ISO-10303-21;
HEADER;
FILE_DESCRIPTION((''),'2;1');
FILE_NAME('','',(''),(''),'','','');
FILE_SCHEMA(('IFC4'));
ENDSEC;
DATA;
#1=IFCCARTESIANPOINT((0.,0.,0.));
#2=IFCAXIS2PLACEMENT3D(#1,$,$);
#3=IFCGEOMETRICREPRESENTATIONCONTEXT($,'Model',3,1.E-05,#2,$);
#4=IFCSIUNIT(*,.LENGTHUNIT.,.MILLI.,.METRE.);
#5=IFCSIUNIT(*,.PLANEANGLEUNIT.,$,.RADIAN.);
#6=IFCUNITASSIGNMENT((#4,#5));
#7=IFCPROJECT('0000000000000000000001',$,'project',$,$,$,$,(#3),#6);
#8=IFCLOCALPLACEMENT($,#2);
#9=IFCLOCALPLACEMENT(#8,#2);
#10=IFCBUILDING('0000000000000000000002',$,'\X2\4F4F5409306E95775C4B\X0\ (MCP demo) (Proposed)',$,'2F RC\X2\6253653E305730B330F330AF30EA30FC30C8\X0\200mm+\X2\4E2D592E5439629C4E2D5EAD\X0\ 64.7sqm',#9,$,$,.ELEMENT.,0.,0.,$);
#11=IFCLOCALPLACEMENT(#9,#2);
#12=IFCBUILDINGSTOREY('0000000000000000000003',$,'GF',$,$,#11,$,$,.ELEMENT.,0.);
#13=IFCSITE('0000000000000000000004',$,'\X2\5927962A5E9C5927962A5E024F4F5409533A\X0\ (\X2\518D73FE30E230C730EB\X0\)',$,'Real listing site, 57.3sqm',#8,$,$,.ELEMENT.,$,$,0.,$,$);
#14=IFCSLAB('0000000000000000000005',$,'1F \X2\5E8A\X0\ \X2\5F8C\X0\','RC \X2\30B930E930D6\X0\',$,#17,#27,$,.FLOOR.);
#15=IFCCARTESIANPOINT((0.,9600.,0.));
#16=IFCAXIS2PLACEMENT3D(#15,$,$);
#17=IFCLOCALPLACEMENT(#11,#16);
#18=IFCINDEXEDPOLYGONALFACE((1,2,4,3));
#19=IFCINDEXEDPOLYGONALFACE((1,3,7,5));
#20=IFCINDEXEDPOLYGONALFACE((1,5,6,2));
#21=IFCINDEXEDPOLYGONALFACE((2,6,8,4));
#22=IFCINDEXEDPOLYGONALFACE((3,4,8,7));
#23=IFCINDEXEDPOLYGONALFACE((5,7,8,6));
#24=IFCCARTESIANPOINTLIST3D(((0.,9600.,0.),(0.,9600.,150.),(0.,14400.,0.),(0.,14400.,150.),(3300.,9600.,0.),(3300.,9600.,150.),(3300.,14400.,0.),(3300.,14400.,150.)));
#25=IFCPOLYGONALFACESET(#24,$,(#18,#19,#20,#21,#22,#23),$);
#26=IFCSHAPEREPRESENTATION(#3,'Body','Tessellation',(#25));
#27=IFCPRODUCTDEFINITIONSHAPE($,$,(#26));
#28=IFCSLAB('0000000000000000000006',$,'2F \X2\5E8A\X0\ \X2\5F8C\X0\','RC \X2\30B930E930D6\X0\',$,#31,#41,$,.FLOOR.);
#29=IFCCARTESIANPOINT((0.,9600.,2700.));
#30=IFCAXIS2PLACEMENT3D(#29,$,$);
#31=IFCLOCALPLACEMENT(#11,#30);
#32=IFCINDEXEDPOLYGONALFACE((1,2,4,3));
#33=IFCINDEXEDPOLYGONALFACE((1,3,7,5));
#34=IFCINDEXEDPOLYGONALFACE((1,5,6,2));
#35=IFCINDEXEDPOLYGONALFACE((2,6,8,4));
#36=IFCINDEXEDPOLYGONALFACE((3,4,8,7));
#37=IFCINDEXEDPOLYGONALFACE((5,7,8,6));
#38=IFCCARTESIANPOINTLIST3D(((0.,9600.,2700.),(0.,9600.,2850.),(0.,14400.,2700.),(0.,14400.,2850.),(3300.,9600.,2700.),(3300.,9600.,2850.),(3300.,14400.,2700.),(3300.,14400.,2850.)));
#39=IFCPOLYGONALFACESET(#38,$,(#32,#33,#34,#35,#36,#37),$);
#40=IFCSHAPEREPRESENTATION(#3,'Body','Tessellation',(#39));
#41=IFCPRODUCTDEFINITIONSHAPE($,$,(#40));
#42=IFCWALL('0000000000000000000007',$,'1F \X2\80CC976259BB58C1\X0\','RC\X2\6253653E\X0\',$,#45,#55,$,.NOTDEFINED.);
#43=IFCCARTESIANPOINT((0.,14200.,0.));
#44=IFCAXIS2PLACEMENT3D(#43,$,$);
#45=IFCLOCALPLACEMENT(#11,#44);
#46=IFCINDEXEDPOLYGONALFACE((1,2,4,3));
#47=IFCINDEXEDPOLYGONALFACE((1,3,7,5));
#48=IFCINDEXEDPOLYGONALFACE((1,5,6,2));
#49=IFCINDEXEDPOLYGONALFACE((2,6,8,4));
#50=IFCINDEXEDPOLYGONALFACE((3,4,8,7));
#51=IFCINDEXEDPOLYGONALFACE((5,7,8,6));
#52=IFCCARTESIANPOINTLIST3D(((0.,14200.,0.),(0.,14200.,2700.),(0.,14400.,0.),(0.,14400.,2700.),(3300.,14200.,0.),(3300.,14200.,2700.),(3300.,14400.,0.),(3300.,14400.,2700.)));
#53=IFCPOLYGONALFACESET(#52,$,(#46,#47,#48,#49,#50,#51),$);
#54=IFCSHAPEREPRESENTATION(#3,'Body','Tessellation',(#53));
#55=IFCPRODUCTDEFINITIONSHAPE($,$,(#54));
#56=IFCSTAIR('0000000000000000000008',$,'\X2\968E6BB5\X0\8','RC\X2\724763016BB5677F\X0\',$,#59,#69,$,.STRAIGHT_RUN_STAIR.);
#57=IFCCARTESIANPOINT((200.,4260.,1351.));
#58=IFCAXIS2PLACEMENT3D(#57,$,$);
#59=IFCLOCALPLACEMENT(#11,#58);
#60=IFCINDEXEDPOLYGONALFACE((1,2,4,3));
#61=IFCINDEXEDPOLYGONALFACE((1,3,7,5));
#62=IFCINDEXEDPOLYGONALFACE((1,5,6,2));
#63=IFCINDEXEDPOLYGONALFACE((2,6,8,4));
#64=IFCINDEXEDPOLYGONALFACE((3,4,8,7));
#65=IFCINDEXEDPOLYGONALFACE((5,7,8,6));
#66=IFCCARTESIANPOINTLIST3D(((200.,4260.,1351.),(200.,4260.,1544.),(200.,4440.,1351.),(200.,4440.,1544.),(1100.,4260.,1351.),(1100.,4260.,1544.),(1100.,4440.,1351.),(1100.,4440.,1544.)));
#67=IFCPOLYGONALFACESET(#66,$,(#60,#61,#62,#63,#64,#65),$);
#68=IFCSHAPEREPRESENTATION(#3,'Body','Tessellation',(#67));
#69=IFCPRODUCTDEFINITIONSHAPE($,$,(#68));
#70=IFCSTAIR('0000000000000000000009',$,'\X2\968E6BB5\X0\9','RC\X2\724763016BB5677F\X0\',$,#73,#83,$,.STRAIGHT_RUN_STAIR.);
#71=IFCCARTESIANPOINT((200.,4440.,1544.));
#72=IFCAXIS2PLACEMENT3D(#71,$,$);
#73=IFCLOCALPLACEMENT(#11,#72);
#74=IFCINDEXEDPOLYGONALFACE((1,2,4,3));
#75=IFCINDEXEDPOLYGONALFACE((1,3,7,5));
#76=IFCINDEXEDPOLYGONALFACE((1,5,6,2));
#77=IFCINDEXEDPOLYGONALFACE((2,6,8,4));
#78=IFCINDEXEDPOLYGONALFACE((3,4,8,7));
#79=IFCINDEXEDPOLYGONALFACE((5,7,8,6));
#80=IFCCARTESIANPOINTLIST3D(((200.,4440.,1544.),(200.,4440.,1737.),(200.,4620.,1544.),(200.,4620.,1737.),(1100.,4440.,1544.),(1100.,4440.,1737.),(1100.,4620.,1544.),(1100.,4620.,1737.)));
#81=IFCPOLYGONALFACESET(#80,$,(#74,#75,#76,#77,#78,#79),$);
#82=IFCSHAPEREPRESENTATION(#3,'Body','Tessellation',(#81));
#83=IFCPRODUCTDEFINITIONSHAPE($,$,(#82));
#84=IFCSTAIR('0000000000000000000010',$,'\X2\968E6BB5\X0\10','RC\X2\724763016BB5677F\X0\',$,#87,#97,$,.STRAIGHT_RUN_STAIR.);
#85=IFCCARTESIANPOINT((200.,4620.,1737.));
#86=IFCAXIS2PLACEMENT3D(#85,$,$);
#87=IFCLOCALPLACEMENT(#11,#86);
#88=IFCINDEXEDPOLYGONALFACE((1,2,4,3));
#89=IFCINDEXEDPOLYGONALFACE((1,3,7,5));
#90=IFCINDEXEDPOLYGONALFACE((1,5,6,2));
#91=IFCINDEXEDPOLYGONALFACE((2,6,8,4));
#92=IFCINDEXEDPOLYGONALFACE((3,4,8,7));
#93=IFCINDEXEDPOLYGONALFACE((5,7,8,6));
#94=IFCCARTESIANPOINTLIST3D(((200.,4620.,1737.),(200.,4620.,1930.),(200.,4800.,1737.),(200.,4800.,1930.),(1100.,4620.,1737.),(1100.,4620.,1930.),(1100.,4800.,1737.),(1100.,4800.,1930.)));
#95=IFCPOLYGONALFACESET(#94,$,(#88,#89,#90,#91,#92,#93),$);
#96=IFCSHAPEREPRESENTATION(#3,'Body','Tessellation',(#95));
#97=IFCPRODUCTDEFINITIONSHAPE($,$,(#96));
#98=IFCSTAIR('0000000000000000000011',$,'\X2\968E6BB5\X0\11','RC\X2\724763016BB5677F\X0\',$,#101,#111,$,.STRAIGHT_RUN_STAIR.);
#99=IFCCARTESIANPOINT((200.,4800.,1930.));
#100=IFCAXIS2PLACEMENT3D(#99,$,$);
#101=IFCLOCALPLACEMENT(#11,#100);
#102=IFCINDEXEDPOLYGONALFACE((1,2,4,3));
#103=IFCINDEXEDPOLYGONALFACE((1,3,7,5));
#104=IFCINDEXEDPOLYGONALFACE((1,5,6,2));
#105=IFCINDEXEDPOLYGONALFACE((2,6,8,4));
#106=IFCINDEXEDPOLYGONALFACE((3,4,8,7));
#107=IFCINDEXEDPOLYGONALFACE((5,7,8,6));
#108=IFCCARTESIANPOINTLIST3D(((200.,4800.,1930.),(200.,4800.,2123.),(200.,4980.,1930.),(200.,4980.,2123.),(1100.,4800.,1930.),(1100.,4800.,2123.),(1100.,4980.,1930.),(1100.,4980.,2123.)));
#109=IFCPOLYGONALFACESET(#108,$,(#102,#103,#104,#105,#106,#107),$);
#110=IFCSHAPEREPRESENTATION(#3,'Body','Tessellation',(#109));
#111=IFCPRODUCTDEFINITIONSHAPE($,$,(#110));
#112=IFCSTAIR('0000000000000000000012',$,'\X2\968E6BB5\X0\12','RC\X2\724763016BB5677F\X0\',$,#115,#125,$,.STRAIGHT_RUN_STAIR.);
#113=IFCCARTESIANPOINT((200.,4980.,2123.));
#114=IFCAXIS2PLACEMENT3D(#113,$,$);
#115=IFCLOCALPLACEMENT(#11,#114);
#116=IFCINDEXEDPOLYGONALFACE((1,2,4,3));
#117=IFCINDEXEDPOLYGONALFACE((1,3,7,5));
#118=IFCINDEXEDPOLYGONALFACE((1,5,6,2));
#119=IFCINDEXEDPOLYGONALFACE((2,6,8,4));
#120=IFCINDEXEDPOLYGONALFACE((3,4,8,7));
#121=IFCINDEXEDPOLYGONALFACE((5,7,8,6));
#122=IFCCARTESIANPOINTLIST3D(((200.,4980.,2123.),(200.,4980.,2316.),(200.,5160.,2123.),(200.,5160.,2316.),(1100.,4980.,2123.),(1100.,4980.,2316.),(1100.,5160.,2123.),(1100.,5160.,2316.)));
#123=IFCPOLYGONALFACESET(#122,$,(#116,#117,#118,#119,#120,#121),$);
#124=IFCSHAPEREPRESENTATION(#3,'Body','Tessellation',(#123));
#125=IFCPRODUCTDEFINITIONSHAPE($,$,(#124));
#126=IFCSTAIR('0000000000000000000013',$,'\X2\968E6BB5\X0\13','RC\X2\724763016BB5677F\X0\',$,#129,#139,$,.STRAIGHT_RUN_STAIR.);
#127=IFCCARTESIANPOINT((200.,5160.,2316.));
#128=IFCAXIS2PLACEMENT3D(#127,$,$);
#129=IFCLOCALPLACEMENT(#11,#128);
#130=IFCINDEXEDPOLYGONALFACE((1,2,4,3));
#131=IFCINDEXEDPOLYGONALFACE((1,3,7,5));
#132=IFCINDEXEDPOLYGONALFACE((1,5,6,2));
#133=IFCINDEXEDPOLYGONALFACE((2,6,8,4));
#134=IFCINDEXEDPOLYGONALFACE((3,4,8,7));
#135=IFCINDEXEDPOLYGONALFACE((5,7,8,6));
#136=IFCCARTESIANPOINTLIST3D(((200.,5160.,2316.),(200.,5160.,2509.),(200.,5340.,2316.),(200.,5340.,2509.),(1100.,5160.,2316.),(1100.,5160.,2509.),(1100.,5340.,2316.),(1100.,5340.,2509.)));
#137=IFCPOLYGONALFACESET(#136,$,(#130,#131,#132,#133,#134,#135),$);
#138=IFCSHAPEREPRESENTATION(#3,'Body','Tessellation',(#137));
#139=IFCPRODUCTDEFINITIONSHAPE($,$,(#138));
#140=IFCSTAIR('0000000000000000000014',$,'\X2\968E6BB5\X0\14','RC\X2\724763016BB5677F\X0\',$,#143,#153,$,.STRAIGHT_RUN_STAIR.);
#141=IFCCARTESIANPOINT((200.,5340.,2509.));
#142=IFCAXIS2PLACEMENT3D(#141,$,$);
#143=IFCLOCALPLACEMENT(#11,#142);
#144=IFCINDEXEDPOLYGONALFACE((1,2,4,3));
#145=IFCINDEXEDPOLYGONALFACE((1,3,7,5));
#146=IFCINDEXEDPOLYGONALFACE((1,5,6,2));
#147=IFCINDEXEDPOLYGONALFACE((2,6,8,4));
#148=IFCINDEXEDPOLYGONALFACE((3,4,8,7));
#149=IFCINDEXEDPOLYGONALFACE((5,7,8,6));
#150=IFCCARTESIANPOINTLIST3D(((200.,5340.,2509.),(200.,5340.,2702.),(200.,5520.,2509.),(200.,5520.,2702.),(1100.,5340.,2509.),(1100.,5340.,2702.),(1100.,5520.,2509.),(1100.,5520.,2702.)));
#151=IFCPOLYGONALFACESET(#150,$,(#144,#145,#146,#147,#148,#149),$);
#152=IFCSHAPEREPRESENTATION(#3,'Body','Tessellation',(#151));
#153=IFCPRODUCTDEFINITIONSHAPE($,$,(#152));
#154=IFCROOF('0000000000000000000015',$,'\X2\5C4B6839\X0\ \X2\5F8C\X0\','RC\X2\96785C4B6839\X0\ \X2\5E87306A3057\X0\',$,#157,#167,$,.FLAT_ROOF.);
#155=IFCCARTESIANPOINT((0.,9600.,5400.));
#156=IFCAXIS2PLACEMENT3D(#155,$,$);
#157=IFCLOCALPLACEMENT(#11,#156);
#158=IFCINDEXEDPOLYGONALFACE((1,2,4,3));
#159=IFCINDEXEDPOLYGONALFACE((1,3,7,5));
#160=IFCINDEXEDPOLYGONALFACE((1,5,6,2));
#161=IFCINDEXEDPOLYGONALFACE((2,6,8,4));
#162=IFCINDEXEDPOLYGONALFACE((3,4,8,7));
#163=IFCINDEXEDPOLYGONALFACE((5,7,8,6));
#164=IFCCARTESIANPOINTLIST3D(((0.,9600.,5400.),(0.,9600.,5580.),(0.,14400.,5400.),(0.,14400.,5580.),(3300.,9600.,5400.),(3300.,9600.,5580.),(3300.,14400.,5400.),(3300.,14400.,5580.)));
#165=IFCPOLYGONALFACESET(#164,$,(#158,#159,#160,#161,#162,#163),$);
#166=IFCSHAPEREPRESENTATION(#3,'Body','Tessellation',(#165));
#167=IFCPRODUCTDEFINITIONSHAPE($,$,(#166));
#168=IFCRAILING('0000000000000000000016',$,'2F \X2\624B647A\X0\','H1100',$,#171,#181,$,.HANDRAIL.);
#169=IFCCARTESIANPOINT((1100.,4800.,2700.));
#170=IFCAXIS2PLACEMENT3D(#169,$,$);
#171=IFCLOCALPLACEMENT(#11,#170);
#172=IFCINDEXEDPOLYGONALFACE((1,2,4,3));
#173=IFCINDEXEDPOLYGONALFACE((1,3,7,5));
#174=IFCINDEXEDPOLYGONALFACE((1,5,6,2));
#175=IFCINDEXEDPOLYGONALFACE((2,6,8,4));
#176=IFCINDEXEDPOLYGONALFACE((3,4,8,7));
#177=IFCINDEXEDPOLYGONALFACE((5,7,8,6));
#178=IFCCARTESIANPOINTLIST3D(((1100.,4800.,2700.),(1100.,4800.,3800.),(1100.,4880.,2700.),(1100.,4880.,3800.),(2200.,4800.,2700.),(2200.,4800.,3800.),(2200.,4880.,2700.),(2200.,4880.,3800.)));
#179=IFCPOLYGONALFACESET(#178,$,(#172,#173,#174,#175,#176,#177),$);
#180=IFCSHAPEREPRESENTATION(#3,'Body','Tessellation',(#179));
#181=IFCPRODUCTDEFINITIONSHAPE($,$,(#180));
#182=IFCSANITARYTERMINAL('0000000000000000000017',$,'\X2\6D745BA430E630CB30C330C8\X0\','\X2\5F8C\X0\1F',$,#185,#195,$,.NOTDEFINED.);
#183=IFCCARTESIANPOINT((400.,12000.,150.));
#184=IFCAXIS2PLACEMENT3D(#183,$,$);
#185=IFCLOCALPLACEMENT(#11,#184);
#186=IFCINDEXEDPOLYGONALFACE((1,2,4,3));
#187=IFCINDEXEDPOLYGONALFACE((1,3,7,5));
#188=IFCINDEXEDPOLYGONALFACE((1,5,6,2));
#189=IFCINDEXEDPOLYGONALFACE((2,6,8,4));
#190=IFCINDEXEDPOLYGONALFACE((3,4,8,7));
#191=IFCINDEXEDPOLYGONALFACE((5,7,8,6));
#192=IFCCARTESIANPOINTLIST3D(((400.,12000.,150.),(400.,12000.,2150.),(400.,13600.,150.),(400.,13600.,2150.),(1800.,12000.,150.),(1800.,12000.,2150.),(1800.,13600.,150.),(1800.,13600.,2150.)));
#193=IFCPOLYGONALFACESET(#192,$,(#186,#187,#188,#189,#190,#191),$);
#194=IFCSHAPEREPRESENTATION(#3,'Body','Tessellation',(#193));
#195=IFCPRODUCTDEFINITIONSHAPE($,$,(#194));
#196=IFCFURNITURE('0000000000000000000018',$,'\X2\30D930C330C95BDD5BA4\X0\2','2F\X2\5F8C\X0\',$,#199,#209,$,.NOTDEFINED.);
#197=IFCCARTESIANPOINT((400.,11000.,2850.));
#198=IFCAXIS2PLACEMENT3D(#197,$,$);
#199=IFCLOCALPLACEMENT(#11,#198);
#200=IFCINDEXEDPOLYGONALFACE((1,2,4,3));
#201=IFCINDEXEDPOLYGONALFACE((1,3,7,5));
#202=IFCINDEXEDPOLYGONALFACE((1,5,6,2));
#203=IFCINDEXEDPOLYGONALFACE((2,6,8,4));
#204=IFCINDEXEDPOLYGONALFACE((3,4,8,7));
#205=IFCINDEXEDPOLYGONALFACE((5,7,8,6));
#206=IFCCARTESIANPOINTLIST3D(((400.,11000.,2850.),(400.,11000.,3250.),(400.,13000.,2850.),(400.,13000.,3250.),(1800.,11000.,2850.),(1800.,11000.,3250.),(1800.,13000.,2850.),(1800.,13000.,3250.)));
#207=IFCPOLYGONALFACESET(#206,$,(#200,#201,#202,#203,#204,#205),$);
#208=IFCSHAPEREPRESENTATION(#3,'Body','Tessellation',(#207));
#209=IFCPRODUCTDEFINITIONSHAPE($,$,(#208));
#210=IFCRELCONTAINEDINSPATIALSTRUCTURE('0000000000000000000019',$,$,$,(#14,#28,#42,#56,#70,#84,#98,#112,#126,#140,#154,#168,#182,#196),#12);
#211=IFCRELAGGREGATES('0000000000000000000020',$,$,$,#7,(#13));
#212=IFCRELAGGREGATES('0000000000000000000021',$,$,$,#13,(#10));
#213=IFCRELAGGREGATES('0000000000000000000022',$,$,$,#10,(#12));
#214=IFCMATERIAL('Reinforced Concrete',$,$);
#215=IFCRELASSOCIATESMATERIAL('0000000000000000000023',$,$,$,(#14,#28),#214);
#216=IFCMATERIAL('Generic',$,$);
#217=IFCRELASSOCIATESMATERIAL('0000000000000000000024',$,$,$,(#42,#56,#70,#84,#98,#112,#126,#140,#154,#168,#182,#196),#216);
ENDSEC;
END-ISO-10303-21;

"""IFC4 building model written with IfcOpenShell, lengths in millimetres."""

from ifc_helpers import new_model, si_unit, frame, frame_2d, origin, place, context, project, spatial, rectangle, extrude, material, element, save


model = new_model("IFC4")

# Units and contexts
model_context = context("Model", 3, precision=1e-05, world=origin())
ifc_project = project(units=[si_unit("LENGTHUNIT", "METRE", prefix="MILLI"), si_unit("PLANEANGLEUNIT", "RADIAN")], contexts=[model_context])

# Site, building, storey
site_placement = place(None, origin())
site = spatial("IfcSite", under=ifc_project, at=site_placement, Name="大阪府大阪市住吉区 (再現モデル)", ObjectType="Real listing site, 57.3sqm", CompositionType="ELEMENT", RefElevation=0.0)
building_placement = place(site_placement, origin())
building = spatial("IfcBuilding", under=site, at=building_placement, Name="住吉の長屋 (MCP demo) (Proposed)", ObjectType="2F RC打放しコンクリート200mm+中央吹抜中庭 64.7sqm", CompositionType="ELEMENT", ElevationOfRefHeight=0.0, ElevationOfTerrain=0.0)
storey_placement = place(building_placement, origin())
storey = spatial("IfcBuildingStorey", under=building, at=storey_placement, Name="GF", CompositionType="ELEMENT", Elevation=0.0)

# Slabs
ifc_material_1 = material(Name="Generic")
ifc_material_2 = material(Name="Reinforced Concrete")
slab_1_placement = place(storey_placement, frame((0.0, 9600.0, 0.0)))
element("IfcSlab", 1, at=slab_1_placement, inside=storey, material=ifc_material_2, Name="1F 床 後", Description="RC スラブ", PredefinedType="FLOOR", context=model_context, shape_type="SweptSolid", body=[
    extrude(rectangle(XDim=3300.0, YDim=4800.0, at=frame_2d((1650.0, 2400.0))), frame((0.0, 9600.0, 0.0)), (0.0, 0.0, 1.0), 150.0),
])
slab_2_placement = place(storey_placement, frame((0.0, 9600.0, 2700.0)))
element("IfcSlab", 2, at=slab_2_placement, inside=storey, material=ifc_material_2, Name="2F 床 後", Description="RC スラブ", PredefinedType="FLOOR", context=model_context, shape_type="SweptSolid", body=[
    extrude(rectangle(XDim=3300.0, YDim=4800.0, at=frame_2d((1650.0, 2400.0))), frame((0.0, 9600.0, 2700.0)), (0.0, 0.0, 1.0), 150.0),
])

# Wall
wall_1_placement = place(storey_placement, frame((0.0, 14200.0, 0.0)))
element("IfcWall", 3, at=wall_1_placement, inside=storey, material=ifc_material_1, Name="1F 背面妻壁", Description="RC打放", PredefinedType="NOTDEFINED", context=model_context, shape_type="SweptSolid", body=[
    extrude(rectangle(XDim=3300.0, YDim=200.0, at=frame_2d((1650.0, 100.0))), frame((0.0, 14200.0, 0.0)), (0.0, 0.0, 1.0), 2700.0),
])

# Stairs
stair_1_placement = place(storey_placement, frame((200.0, 4260.0, 1351.0)))
element("IfcStair", 4, at=stair_1_placement, inside=storey, material=ifc_material_1, Name="階段8", Description="RC片持段板", PredefinedType="STRAIGHT_RUN_STAIR", context=model_context, shape_type="SweptSolid", body=[
    extrude(rectangle(XDim=900.0, YDim=180.0, at=frame_2d((450.0, 90.0))), frame((200.0, 4260.0, 1351.0)), (0.0, 0.0, 1.0), 193.0),
])
stair_2_placement = place(storey_placement, frame((200.0, 4440.0, 1544.0)))
element("IfcStair", 5, at=stair_2_placement, inside=storey, material=ifc_material_1, Name="階段9", Description="RC片持段板", PredefinedType="STRAIGHT_RUN_STAIR", context=model_context, shape_type="SweptSolid", body=[
    extrude(rectangle(XDim=900.0, YDim=180.0, at=frame_2d((450.0, 90.0))), frame((200.0, 4440.0, 1544.0)), (0.0, 0.0, 1.0), 193.0),
])
stair_3_placement = place(storey_placement, frame((200.0, 4620.0, 1737.0)))
element("IfcStair", 6, at=stair_3_placement, inside=storey, material=ifc_material_1, Name="階段10", Description="RC片持段板", PredefinedType="STRAIGHT_RUN_STAIR", context=model_context, shape_type="SweptSolid", body=[
    extrude(rectangle(XDim=900.0, YDim=180.0, at=frame_2d((450.0, 90.0))), frame((200.0, 4620.0, 1737.0)), (0.0, 0.0, 1.0), 193.0),
])
stair_4_placement = place(storey_placement, frame((200.0, 4800.0, 1930.0)))
element("IfcStair", 7, at=stair_4_placement, inside=storey, material=ifc_material_1, Name="階段11", Description="RC片持段板", PredefinedType="STRAIGHT_RUN_STAIR", context=model_context, shape_type="SweptSolid", body=[
    extrude(rectangle(XDim=900.0, YDim=180.0, at=frame_2d((450.0, 90.0))), frame((200.0, 4800.0, 1930.0)), (0.0, 0.0, 1.0), 193.0),
])
stair_5_placement = place(storey_placement, frame((200.0, 4980.0, 2123.0)))
element("IfcStair", 8, at=stair_5_placement, inside=storey, material=ifc_material_1, Name="階段12", Description="RC片持段板", PredefinedType="STRAIGHT_RUN_STAIR", context=model_context, shape_type="SweptSolid", body=[
    extrude(rectangle(XDim=900.0, YDim=180.0, at=frame_2d((450.0, 90.0))), frame((200.0, 4980.0, 2123.0)), (0.0, 0.0, 1.0), 193.0),
])
stair_6_placement = place(storey_placement, frame((200.0, 5160.0, 2316.0)))
element("IfcStair", 9, at=stair_6_placement, inside=storey, material=ifc_material_1, Name="階段13", Description="RC片持段板", PredefinedType="STRAIGHT_RUN_STAIR", context=model_context, shape_type="SweptSolid", body=[
    extrude(rectangle(XDim=900.0, YDim=180.0, at=frame_2d((450.0, 90.0))), frame((200.0, 5160.0, 2316.0)), (0.0, 0.0, 1.0), 193.0),
])
stair_7_placement = place(storey_placement, frame((200.0, 5340.0, 2509.0)))
element("IfcStair", 10, at=stair_7_placement, inside=storey, material=ifc_material_1, Name="階段14", Description="RC片持段板", PredefinedType="STRAIGHT_RUN_STAIR", context=model_context, shape_type="SweptSolid", body=[
    extrude(rectangle(XDim=900.0, YDim=180.0, at=frame_2d((450.0, 90.0))), frame((200.0, 5340.0, 2509.0)), (0.0, 0.0, 1.0), 193.0),
])

# Roof
roof_placement = place(storey_placement, frame((0.0, 9600.0, 5400.0)))
element("IfcRoof", 11, at=roof_placement, inside=storey, material=ifc_material_1, Name="屋根 後", Description="RC陸屋根 庇なし", PredefinedType="FLAT_ROOF", context=model_context, shape_type="SweptSolid", body=[
    extrude(rectangle(XDim=3300.0, YDim=4800.0, at=frame_2d((1650.0, 2400.0))), frame((0.0, 9600.0, 5400.0)), (0.0, 0.0, 1.0), 180.0),
])

# Railing
railing_placement = place(storey_placement, frame((1100.0, 4800.0, 2700.0)))
element("IfcRailing", 12, at=railing_placement, inside=storey, material=ifc_material_1, Name="2F 手摺", Description="H1100", PredefinedType="HANDRAIL", context=model_context, shape_type="SweptSolid", body=[
    extrude(rectangle(XDim=1100.0, YDim=80.0, at=frame_2d((550.0, 40.0))), frame((1100.0, 4800.0, 2700.0)), (0.0, 0.0, 1.0), 1100.0),
])

# Sanitary terminal
sanitary_terminal_placement = place(storey_placement, frame((400.0, 12000.0, 150.0)))
element("IfcSanitaryTerminal", 13, at=sanitary_terminal_placement, inside=storey, material=ifc_material_1, Name="浴室ユニット", Description="後1F", PredefinedType="NOTDEFINED", context=model_context, shape_type="SweptSolid", body=[
    extrude(rectangle(XDim=1400.0, YDim=1600.0, at=frame_2d((700.0, 800.0))), frame((400.0, 12000.0, 150.0)), (0.0, 0.0, 1.0), 2000.0),
])

# Furniture
furniture_placement = place(storey_placement, frame((400.0, 11000.0, 2850.0)))
element("IfcFurniture", 14, at=furniture_placement, inside=storey, material=ifc_material_1, Name="ベッド寝室2", Description="2F後", PredefinedType="NOTDEFINED", context=model_context, shape_type="SweptSolid", body=[
    extrude(rectangle(XDim=1400.0, YDim=2000.0, at=frame_2d((700.0, 1000.0))), frame((400.0, 11000.0, 2850.0)), (0.0, 0.0, 1.0), 400.0),
])

save(model, "model.ifc")
